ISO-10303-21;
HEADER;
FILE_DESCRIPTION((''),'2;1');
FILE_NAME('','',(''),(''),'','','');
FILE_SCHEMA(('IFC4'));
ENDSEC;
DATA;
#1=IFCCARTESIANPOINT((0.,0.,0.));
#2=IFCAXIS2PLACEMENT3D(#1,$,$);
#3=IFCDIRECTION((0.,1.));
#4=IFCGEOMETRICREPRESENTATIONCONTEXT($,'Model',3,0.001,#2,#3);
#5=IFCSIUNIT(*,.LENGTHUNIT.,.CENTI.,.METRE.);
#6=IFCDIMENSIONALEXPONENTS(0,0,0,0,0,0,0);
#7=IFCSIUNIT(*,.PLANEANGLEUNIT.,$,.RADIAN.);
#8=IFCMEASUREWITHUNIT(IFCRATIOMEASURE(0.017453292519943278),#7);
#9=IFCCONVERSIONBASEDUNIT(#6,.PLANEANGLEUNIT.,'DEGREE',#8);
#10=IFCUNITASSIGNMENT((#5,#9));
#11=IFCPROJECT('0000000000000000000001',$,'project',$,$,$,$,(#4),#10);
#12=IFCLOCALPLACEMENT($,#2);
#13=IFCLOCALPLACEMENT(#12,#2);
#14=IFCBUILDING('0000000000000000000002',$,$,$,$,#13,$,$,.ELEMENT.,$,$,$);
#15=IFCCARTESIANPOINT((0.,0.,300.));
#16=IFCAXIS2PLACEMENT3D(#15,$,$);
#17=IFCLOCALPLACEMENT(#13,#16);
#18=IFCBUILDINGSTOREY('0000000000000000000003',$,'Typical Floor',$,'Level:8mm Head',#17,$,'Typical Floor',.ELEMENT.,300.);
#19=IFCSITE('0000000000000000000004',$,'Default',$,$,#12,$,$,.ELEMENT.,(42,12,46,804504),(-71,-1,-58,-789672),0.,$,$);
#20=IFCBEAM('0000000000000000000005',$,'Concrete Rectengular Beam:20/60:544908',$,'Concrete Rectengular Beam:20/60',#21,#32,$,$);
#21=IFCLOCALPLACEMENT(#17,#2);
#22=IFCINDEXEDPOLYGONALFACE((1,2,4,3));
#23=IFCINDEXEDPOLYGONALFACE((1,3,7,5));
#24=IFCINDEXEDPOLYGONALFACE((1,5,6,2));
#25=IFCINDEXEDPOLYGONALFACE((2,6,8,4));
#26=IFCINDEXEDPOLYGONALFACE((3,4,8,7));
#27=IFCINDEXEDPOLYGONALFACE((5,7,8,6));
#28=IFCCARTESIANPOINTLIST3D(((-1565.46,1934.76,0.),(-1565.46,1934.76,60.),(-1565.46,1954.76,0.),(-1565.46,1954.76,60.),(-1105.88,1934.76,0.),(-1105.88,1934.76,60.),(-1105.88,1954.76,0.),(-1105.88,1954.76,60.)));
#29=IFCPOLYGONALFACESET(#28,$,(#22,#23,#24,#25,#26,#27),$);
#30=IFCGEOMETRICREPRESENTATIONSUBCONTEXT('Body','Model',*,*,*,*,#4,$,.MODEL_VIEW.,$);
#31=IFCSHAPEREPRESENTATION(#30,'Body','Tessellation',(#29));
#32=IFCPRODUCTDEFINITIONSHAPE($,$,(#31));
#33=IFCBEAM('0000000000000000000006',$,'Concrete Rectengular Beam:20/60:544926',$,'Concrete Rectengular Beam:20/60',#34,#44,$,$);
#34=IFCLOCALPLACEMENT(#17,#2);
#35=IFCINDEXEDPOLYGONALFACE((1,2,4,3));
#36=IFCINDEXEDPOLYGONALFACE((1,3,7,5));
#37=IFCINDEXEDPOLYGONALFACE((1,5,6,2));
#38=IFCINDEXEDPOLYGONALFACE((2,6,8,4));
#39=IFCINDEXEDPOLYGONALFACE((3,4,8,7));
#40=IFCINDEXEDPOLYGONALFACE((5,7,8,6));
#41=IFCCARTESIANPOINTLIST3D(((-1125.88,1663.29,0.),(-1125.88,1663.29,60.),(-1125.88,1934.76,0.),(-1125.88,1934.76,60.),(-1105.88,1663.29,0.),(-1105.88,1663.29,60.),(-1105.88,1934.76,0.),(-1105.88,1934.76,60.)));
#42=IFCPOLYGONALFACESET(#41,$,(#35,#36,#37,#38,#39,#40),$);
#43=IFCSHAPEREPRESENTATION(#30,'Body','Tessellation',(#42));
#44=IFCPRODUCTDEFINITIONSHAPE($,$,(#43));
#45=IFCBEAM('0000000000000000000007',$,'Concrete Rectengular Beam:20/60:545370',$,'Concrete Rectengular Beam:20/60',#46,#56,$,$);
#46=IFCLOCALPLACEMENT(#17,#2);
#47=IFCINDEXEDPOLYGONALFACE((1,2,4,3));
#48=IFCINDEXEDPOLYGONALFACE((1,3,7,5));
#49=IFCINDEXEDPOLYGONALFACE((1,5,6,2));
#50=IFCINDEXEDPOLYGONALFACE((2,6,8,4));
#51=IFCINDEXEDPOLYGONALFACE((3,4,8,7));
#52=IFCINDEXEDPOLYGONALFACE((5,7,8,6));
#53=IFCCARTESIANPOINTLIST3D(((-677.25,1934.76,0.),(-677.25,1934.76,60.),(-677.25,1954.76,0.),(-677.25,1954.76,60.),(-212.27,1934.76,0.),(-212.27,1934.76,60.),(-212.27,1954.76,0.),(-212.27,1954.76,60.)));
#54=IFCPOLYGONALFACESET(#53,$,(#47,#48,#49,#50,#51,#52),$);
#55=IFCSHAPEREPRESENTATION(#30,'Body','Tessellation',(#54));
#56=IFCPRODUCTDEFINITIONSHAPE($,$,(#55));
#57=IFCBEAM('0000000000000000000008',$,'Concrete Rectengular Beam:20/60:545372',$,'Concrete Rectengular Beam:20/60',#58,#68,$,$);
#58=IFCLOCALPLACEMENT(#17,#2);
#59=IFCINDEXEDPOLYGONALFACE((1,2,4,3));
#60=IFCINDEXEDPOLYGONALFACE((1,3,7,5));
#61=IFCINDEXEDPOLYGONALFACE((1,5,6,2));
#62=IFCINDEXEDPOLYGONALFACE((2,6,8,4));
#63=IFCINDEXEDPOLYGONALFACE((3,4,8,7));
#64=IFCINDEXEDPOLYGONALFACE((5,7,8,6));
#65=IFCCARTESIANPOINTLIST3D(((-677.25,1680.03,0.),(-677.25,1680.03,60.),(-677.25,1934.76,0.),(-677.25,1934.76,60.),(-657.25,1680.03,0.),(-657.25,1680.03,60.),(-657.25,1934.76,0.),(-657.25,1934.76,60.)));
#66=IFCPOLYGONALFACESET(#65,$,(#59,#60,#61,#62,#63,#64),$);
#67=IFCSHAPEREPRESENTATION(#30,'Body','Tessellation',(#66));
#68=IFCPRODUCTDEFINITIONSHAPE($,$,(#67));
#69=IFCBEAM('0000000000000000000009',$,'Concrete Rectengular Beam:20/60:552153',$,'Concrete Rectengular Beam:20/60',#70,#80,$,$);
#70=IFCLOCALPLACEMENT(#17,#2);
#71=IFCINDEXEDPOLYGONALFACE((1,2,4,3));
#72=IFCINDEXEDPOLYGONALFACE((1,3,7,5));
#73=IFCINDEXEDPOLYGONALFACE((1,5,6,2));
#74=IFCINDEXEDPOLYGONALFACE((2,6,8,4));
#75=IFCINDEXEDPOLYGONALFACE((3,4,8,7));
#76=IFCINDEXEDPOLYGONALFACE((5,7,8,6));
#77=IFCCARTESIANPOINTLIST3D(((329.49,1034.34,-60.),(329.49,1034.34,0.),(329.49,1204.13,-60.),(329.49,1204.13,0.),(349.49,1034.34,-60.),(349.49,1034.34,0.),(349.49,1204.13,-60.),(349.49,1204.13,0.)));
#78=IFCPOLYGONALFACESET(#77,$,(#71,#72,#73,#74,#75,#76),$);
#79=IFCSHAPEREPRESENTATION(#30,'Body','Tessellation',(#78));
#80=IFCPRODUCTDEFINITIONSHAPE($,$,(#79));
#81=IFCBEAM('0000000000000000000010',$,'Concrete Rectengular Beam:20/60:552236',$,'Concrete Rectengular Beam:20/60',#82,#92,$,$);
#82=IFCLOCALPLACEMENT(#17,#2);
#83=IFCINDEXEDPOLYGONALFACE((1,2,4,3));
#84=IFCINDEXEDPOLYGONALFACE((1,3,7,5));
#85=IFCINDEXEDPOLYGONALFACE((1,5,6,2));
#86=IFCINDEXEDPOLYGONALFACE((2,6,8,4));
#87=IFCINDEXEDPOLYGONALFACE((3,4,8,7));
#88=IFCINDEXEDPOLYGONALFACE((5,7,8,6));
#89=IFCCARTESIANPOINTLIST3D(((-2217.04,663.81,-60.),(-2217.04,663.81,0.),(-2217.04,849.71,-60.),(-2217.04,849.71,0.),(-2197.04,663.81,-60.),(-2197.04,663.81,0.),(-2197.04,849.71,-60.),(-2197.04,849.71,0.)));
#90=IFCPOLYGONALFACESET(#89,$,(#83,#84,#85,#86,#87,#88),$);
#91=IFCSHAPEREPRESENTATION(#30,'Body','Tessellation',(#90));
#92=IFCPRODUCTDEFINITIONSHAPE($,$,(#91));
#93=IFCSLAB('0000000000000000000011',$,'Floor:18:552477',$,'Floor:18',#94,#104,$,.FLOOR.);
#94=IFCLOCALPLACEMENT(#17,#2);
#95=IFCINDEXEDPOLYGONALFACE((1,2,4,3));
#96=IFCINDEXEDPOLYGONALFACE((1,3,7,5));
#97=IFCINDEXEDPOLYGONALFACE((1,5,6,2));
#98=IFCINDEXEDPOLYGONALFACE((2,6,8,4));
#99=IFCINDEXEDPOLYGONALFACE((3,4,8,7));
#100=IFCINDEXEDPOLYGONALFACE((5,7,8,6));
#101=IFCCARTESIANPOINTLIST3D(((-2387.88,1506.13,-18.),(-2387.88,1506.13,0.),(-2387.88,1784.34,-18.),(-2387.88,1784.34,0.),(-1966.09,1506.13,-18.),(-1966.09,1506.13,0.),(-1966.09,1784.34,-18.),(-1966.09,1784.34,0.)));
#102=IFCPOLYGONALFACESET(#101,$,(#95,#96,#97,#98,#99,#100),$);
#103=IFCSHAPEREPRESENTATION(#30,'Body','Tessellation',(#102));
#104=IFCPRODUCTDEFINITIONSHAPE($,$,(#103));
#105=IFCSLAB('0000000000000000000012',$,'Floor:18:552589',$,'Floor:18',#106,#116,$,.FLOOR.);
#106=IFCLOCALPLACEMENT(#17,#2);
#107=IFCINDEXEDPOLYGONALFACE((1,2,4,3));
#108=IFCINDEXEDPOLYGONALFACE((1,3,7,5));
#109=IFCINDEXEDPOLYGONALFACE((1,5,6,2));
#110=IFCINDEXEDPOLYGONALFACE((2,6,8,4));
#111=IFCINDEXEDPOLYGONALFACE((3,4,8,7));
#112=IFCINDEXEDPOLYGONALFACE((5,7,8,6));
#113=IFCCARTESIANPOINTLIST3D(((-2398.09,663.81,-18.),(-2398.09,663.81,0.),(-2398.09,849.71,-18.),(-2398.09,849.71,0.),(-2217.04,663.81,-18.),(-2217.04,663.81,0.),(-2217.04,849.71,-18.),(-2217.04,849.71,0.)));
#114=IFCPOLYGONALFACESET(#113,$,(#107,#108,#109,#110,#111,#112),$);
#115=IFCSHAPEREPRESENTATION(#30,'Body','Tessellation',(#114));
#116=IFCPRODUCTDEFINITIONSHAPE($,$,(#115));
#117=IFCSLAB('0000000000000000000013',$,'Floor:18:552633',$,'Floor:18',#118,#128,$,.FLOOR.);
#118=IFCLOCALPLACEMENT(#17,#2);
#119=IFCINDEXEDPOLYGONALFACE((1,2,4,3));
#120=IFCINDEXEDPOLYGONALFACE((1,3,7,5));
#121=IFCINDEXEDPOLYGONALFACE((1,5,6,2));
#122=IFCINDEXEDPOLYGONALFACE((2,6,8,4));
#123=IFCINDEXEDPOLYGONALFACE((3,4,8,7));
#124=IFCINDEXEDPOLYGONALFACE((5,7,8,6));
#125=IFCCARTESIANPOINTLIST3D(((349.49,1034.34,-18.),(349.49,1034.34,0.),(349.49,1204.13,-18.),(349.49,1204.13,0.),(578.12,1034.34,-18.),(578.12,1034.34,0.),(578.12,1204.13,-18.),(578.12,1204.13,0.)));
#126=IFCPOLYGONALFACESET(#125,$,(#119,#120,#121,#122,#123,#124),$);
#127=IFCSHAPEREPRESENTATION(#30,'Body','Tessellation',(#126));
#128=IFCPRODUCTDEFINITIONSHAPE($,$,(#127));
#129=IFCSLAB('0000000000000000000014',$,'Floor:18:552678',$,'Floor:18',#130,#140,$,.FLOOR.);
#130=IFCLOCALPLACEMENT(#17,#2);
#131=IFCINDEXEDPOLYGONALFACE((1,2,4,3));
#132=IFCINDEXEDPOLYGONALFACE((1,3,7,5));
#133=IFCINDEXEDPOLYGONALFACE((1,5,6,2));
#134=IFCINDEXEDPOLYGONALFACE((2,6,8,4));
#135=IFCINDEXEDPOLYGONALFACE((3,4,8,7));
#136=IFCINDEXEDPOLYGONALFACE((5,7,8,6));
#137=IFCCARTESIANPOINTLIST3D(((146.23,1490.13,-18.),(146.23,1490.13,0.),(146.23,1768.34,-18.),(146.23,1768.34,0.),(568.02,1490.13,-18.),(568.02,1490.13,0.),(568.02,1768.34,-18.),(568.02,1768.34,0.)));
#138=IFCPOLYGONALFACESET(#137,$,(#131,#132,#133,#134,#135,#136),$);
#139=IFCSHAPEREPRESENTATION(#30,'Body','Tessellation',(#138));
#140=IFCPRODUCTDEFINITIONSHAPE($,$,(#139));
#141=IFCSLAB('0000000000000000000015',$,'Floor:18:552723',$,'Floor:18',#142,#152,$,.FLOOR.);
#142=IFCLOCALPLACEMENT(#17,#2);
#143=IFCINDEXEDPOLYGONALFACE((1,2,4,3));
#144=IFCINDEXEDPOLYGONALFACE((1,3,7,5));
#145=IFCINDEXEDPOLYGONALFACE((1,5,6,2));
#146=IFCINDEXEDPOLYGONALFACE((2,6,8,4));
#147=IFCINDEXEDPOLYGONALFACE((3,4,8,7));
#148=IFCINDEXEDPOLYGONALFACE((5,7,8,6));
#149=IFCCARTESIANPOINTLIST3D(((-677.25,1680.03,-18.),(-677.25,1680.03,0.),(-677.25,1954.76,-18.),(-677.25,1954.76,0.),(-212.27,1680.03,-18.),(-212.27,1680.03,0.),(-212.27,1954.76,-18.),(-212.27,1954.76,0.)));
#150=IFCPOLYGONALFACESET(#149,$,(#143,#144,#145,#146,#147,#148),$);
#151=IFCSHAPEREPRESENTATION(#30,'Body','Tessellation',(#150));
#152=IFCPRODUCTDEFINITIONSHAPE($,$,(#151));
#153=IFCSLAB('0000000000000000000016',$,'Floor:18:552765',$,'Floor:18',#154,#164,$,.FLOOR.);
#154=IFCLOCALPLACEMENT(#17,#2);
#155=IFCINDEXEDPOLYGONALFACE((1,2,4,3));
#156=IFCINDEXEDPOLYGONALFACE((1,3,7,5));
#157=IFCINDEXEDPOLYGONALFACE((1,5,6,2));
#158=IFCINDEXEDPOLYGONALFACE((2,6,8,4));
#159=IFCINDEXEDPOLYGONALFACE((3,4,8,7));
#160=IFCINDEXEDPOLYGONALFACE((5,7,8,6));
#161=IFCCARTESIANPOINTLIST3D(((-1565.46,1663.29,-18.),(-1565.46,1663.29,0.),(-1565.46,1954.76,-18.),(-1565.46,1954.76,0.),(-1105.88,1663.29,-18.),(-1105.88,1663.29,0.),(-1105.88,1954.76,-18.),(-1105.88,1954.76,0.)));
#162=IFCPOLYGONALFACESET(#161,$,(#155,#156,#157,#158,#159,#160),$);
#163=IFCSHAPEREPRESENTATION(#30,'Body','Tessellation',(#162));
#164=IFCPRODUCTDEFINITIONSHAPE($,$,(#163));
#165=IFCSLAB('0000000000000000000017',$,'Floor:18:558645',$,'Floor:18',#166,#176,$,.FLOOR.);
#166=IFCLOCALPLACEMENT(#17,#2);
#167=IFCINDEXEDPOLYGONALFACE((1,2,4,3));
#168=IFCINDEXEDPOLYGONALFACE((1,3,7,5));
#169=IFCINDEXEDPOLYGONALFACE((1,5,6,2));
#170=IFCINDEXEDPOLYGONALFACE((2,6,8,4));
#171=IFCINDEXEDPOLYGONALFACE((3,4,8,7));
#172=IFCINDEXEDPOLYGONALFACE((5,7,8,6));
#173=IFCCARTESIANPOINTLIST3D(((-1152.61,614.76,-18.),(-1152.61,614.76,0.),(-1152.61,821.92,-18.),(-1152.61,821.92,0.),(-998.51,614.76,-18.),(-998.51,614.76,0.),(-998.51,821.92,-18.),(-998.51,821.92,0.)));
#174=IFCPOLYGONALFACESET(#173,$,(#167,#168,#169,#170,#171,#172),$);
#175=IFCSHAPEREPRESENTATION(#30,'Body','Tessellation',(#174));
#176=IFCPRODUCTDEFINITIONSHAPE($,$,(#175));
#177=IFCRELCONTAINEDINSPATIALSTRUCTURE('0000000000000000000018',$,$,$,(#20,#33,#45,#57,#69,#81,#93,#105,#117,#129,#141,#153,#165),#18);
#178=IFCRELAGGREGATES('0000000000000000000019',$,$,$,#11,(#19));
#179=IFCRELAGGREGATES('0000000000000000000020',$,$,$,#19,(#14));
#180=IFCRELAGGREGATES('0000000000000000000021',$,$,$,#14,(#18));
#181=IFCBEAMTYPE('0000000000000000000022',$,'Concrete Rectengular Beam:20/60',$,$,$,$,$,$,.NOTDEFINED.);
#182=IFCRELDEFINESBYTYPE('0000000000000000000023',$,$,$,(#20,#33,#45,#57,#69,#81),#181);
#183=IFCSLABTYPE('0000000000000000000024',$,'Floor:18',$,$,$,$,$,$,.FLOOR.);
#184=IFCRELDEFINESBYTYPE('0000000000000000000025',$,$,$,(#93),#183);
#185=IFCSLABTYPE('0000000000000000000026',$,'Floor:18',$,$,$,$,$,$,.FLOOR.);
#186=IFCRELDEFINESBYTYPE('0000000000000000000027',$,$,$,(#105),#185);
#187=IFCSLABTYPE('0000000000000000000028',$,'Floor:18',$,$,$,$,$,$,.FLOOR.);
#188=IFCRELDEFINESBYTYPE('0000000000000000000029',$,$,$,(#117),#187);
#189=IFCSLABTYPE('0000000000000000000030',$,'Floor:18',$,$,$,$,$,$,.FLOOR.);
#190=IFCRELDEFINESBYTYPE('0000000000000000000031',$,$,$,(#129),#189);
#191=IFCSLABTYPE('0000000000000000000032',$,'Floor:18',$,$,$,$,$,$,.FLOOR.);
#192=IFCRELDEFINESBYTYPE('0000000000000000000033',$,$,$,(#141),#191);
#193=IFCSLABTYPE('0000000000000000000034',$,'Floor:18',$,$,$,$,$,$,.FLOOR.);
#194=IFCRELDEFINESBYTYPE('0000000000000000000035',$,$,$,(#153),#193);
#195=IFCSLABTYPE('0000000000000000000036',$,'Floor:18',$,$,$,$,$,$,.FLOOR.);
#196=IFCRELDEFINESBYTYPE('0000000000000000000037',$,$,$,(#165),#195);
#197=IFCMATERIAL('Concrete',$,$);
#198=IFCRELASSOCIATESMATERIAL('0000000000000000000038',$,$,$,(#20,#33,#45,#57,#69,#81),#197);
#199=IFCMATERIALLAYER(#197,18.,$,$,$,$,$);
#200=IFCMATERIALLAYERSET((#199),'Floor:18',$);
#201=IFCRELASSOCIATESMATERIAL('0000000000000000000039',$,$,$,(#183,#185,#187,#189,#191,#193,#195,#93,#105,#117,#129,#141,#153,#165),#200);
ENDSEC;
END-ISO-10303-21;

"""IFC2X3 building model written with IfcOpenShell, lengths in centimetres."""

from ifc_helpers import new_model, entity, si_unit, converted_unit, direction, frame, frame_2d, origin, origin_2d_with_axis, place, context, subcontext, project, spatial, rectangle, extrude, material, layer, layer_set, layer_usage, type_object, element, save


model = new_model("IFC2X3")

# Units and contexts
model_context = context("Model", 3, precision=0.001, world=origin(), true_north=direction((0.0, 1.0)))
body_context = subcontext(model_context, "Body", "Model", "MODEL_VIEW")
ifc_project = project(units=[si_unit("LENGTHUNIT", "METRE", prefix="CENTI"), converted_unit("PLANEANGLEUNIT", "DEGREE", entity("IfcRatioMeasure", 0.017453292519943278), si_unit("PLANEANGLEUNIT", "RADIAN"), dimensions=[0, 0, 0, 0, 0, 0, 0])], contexts=[model_context])

# Site, building, storey
site_placement = place(None, origin())
site = spatial("IfcSite", under=ifc_project, at=site_placement, Name="Default", CompositionType="ELEMENT", RefLatitude=(42, 12, 46, 804504), RefLongitude=(-71, -1, -58, -789672), RefElevation=0.0)
building_placement = place(site_placement, origin())
building = spatial("IfcBuilding", under=site, at=building_placement, CompositionType="ELEMENT")
storey_placement = place(building_placement, frame((0.0, 0.0, 300.0)))
storey = spatial("IfcBuildingStorey", under=building, at=storey_placement, Name="Typical Floor", ObjectType="Level:8mm Head", LongName="Typical Floor", CompositionType="ELEMENT", Elevation=300.0)

# Beams
ifc_material = material(Name="Concrete")
beam_type_1 = type_object("IfcBeamType", Name="Concrete Rectengular Beam:20/60", PredefinedType="NOTDEFINED")
beam_1_placement = place(storey_placement, frame((-1565.46, 1944.76, 0.0)))
element("IfcBeam", 1, at=beam_1_placement, inside=storey, type_object=beam_type_1, material=ifc_material, Name="Concrete Rectengular Beam:20/60:544908", ObjectType="Concrete Rectengular Beam:20/60", context=body_context, shape_type="SweptSolid", body=[
    extrude(rectangle(XDim=60.0, YDim=20.0, at=frame_2d((0.0, 0.0), x_axis=(1.0, 0.0))), frame((0.0, 0.0, 30.0), z_axis=(1.0, 0.0, 0.0), x_axis=(0.0, 0.0, -1.0)), (0.0, 0.0, 1.0), 459.58),
])
beam_2_placement = place(storey_placement, frame((-1115.88, 1944.76, 0.0), z_axis=(0.0, 0.0, 1.0), x_axis=(0.0, -1.0, 0.0)))
element("IfcBeam", 2, at=beam_2_placement, inside=storey, type_object=beam_type_1, material=ifc_material, Name="Concrete Rectengular Beam:20/60:544926", ObjectType="Concrete Rectengular Beam:20/60", context=body_context, shape_type="SweptSolid", body=[
    extrude(rectangle(XDim=60.0, YDim=20.0, at=frame_2d((0.0, 0.0), x_axis=(1.0, 0.0))), frame((10.0, 0.0, 30.0), z_axis=(1.0, 0.0, 0.0), x_axis=(0.0, 0.0, -1.0)), (0.0, 0.0, 1.0), 271.47),
])
beam_3_placement = place(storey_placement, frame((-212.27, 1944.76, 0.0), z_axis=(0.0, 0.0, 1.0), x_axis=(-1.0, 0.0, 0.0)))
element("IfcBeam", 3, at=beam_3_placement, inside=storey, type_object=beam_type_1, material=ifc_material, Name="Concrete Rectengular Beam:20/60:545370", ObjectType="Concrete Rectengular Beam:20/60", context=body_context, shape_type="SweptSolid", body=[
    extrude(rectangle(XDim=60.0, YDim=20.0, at=frame_2d((0.0, 0.0), x_axis=(1.0, 0.0))), frame((0.0, 0.0, 30.0), z_axis=(1.0, 0.0, 0.0), x_axis=(0.0, 0.0, -1.0)), (0.0, 0.0, 1.0), 464.97),
])
beam_4_placement = place(storey_placement, frame((-667.25, 1944.76, 0.0), z_axis=(0.0, 0.0, 1.0), x_axis=(0.0, -1.0, 0.0)))
element("IfcBeam", 4, at=beam_4_placement, inside=storey, type_object=beam_type_1, material=ifc_material, Name="Concrete Rectengular Beam:20/60:545372", ObjectType="Concrete Rectengular Beam:20/60", context=body_context, shape_type="SweptSolid", body=[
    extrude(rectangle(XDim=60.0, YDim=20.0, at=origin_2d_with_axis()), frame((10.0, 0.0, 30.0), z_axis=(1.0, 0.0, 0.0), x_axis=(0.0, 0.0, -1.0)), (0.0, 0.0, 1.0), 254.74),
])
beam_5_placement = place(storey_placement, frame((339.49, 1024.34, 0.0), z_axis=(0.0, 0.0, 1.0), x_axis=(0.0, 1.0, 0.0)))
element("IfcBeam", 5, at=beam_5_placement, inside=storey, type_object=beam_type_1, material=ifc_material, Name="Concrete Rectengular Beam:20/60:552153", ObjectType="Concrete Rectengular Beam:20/60", context=body_context, shape_type="SweptSolid", body=[
    extrude(rectangle(XDim=60.0, YDim=20.0, at=frame_2d((0.0, 0.0), x_axis=(1.0, 0.0))), frame((10.0, 0.0, -30.0), z_axis=(1.0, 0.0, 0.0), x_axis=(0.0, 0.0, -1.0)), (0.0, 0.0, 1.0), 169.79),
])
beam_6_placement = place(storey_placement, frame((-2207.04, 859.71, 0.0), z_axis=(0.0, 0.0, 1.0), x_axis=(0.0, -1.0, 0.0)))
element("IfcBeam", 6, at=beam_6_placement, inside=storey, type_object=beam_type_1, material=ifc_material, Name="Concrete Rectengular Beam:20/60:552236", ObjectType="Concrete Rectengular Beam:20/60", context=body_context, shape_type="SweptSolid", body=[
    extrude(rectangle(XDim=60.0, YDim=20.0, at=frame_2d((0.0, 0.0), x_axis=(1.0, 0.0))), frame((10.0, 0.0, -30.0), z_axis=(1.0, 0.0, 0.0), x_axis=(0.0, 0.0, -1.0)), (0.0, 0.0, 1.0), 185.89),
])

# Slabs
ifc_layer = layer(ifc_material, 18.0)
ifc_layer_set = layer_set([ifc_layer], Name="Floor:18")
ifc_layer_usage_1 = layer_usage(ifc_layer_set, "AXIS3", "POSITIVE", 0.0)
slab_type_1 = type_object("IfcSlabType", Name="Floor:18", PredefinedType="FLOOR", material=ifc_layer_set)
slab_1_placement = place(storey_placement, origin())
element("IfcSlab", 7, at=slab_1_placement, inside=storey, type_object=slab_type_1, material=ifc_layer_usage_1, Name="Floor:18:552477", ObjectType="Floor:18", PredefinedType="FLOOR", context=body_context, shape_type="SweptSolid", body=[
    extrude(rectangle(XDim=278.21, YDim=421.79, at=frame_2d((0.0, 0.0), x_axis=(1.0, 0.0))), frame((-2176.98, 1645.24, 0.0), z_axis=(0.0, 0.0, -1.0), x_axis=(0.0, 1.0, 0.0)), (0.0, 0.0, 1.0), 18.0),
])
ifc_layer_usage_2 = layer_usage(ifc_layer_set, "AXIS3", "POSITIVE", 0.0)
slab_type_2 = type_object("IfcSlabType", Name="Floor:18", PredefinedType="FLOOR", material=ifc_layer_set)
slab_2_placement = place(storey_placement, origin())
element("IfcSlab", 8, at=slab_2_placement, inside=storey, type_object=slab_type_2, material=ifc_layer_usage_2, Name="Floor:18:552589", ObjectType="Floor:18", PredefinedType="FLOOR", context=body_context, shape_type="SweptSolid", body=[
    extrude(rectangle(XDim=185.89, YDim=181.05, at=frame_2d((0.0, 0.0), x_axis=(1.0, 0.0))), frame((-2307.56, 756.76, 0.0), z_axis=(0.0, 0.0, -1.0), x_axis=(0.0, 1.0, 0.0)), (0.0, 0.0, 1.0), 18.0),
])
ifc_layer_usage_3 = layer_usage(ifc_layer_set, "AXIS3", "POSITIVE", 0.0)
slab_type_3 = type_object("IfcSlabType", Name="Floor:18", PredefinedType="FLOOR", material=ifc_layer_set)
slab_3_placement = place(storey_placement, origin())
element("IfcSlab", 9, at=slab_3_placement, inside=storey, type_object=slab_type_3, material=ifc_layer_usage_3, Name="Floor:18:552633", ObjectType="Floor:18", PredefinedType="FLOOR", context=body_context, shape_type="SweptSolid", body=[
    extrude(rectangle(XDim=169.79, YDim=228.63, at=origin_2d_with_axis()), frame((463.81, 1119.24, 0.0), z_axis=(0.0, 0.0, -1.0), x_axis=(0.0, 1.0, 0.0)), (0.0, 0.0, 1.0), 18.0),
])
ifc_layer_usage_4 = layer_usage(ifc_layer_set, "AXIS3", "POSITIVE", 0.0)
slab_type_4 = type_object("IfcSlabType", Name="Floor:18", PredefinedType="FLOOR", material=ifc_layer_set)
slab_4_placement = place(storey_placement, origin())
element("IfcSlab", 10, at=slab_4_placement, inside=storey, type_object=slab_type_4, material=ifc_layer_usage_4, Name="Floor:18:552678", ObjectType="Floor:18", PredefinedType="FLOOR", context=body_context, shape_type="SweptSolid", body=[
    extrude(rectangle(XDim=278.21, YDim=421.79, at=frame_2d((0.0, 0.0), x_axis=(1.0, 0.0))), frame((357.12, 1629.24, 0.0), z_axis=(0.0, 0.0, -1.0), x_axis=(0.0, 1.0, 0.0)), (0.0, 0.0, 1.0), 18.0),
])
ifc_layer_usage_5 = layer_usage(ifc_layer_set, "AXIS3", "POSITIVE", 0.0)
slab_type_5 = type_object("IfcSlabType", Name="Floor:18", PredefinedType="FLOOR", material=ifc_layer_set)
slab_5_placement = place(storey_placement, origin())
element("IfcSlab", 11, at=slab_5_placement, inside=storey, type_object=slab_type_5, material=ifc_layer_usage_5, Name="Floor:18:552723", ObjectType="Floor:18", PredefinedType="FLOOR", context=body_context, shape_type="SweptSolid", body=[
    extrude(rectangle(XDim=274.74, YDim=464.97, at=frame_2d((0.0, 0.0), x_axis=(1.0, 0.0))), frame((-444.76, 1817.39, 0.0), z_axis=(0.0, 0.0, -1.0), x_axis=(0.0, 1.0, 0.0)), (0.0, 0.0, 1.0), 18.0),
])
ifc_layer_usage_6 = layer_usage(ifc_layer_set, "AXIS3", "POSITIVE", 0.0)
slab_type_6 = type_object("IfcSlabType", Name="Floor:18", PredefinedType="FLOOR", material=ifc_layer_set)
slab_6_placement = place(storey_placement, origin())
element("IfcSlab", 12, at=slab_6_placement, inside=storey, type_object=slab_type_6, material=ifc_layer_usage_6, Name="Floor:18:552765", ObjectType="Floor:18", PredefinedType="FLOOR", context=body_context, shape_type="SweptSolid", body=[
    extrude(rectangle(XDim=291.47, YDim=459.58, at=frame_2d((0.0, 0.0), x_axis=(1.0, 0.0))), frame((-1335.67, 1809.03, 0.0), z_axis=(0.0, 0.0, -1.0), x_axis=(0.0, 1.0, 0.0)), (0.0, 0.0, 1.0), 18.0),
])
ifc_layer_usage_7 = layer_usage(ifc_layer_set, "AXIS3", "POSITIVE", 0.0)
slab_type_7 = type_object("IfcSlabType", Name="Floor:18", PredefinedType="FLOOR", material=ifc_layer_set)
slab_7_placement = place(storey_placement, origin())
element("IfcSlab", 13, at=slab_7_placement, inside=storey, type_object=slab_type_7, material=ifc_layer_usage_7, Name="Floor:18:558645", ObjectType="Floor:18", PredefinedType="FLOOR", context=body_context, shape_type="SweptSolid", body=[
    extrude(rectangle(XDim=207.16, YDim=154.11, at=origin_2d_with_axis()), frame((-1075.56, 718.34, 0.0), z_axis=(0.0, 0.0, -1.0), x_axis=(0.0, 1.0, 0.0)), (0.0, 0.0, 1.0), 18.0),
])

save(model, "model.ifc")
